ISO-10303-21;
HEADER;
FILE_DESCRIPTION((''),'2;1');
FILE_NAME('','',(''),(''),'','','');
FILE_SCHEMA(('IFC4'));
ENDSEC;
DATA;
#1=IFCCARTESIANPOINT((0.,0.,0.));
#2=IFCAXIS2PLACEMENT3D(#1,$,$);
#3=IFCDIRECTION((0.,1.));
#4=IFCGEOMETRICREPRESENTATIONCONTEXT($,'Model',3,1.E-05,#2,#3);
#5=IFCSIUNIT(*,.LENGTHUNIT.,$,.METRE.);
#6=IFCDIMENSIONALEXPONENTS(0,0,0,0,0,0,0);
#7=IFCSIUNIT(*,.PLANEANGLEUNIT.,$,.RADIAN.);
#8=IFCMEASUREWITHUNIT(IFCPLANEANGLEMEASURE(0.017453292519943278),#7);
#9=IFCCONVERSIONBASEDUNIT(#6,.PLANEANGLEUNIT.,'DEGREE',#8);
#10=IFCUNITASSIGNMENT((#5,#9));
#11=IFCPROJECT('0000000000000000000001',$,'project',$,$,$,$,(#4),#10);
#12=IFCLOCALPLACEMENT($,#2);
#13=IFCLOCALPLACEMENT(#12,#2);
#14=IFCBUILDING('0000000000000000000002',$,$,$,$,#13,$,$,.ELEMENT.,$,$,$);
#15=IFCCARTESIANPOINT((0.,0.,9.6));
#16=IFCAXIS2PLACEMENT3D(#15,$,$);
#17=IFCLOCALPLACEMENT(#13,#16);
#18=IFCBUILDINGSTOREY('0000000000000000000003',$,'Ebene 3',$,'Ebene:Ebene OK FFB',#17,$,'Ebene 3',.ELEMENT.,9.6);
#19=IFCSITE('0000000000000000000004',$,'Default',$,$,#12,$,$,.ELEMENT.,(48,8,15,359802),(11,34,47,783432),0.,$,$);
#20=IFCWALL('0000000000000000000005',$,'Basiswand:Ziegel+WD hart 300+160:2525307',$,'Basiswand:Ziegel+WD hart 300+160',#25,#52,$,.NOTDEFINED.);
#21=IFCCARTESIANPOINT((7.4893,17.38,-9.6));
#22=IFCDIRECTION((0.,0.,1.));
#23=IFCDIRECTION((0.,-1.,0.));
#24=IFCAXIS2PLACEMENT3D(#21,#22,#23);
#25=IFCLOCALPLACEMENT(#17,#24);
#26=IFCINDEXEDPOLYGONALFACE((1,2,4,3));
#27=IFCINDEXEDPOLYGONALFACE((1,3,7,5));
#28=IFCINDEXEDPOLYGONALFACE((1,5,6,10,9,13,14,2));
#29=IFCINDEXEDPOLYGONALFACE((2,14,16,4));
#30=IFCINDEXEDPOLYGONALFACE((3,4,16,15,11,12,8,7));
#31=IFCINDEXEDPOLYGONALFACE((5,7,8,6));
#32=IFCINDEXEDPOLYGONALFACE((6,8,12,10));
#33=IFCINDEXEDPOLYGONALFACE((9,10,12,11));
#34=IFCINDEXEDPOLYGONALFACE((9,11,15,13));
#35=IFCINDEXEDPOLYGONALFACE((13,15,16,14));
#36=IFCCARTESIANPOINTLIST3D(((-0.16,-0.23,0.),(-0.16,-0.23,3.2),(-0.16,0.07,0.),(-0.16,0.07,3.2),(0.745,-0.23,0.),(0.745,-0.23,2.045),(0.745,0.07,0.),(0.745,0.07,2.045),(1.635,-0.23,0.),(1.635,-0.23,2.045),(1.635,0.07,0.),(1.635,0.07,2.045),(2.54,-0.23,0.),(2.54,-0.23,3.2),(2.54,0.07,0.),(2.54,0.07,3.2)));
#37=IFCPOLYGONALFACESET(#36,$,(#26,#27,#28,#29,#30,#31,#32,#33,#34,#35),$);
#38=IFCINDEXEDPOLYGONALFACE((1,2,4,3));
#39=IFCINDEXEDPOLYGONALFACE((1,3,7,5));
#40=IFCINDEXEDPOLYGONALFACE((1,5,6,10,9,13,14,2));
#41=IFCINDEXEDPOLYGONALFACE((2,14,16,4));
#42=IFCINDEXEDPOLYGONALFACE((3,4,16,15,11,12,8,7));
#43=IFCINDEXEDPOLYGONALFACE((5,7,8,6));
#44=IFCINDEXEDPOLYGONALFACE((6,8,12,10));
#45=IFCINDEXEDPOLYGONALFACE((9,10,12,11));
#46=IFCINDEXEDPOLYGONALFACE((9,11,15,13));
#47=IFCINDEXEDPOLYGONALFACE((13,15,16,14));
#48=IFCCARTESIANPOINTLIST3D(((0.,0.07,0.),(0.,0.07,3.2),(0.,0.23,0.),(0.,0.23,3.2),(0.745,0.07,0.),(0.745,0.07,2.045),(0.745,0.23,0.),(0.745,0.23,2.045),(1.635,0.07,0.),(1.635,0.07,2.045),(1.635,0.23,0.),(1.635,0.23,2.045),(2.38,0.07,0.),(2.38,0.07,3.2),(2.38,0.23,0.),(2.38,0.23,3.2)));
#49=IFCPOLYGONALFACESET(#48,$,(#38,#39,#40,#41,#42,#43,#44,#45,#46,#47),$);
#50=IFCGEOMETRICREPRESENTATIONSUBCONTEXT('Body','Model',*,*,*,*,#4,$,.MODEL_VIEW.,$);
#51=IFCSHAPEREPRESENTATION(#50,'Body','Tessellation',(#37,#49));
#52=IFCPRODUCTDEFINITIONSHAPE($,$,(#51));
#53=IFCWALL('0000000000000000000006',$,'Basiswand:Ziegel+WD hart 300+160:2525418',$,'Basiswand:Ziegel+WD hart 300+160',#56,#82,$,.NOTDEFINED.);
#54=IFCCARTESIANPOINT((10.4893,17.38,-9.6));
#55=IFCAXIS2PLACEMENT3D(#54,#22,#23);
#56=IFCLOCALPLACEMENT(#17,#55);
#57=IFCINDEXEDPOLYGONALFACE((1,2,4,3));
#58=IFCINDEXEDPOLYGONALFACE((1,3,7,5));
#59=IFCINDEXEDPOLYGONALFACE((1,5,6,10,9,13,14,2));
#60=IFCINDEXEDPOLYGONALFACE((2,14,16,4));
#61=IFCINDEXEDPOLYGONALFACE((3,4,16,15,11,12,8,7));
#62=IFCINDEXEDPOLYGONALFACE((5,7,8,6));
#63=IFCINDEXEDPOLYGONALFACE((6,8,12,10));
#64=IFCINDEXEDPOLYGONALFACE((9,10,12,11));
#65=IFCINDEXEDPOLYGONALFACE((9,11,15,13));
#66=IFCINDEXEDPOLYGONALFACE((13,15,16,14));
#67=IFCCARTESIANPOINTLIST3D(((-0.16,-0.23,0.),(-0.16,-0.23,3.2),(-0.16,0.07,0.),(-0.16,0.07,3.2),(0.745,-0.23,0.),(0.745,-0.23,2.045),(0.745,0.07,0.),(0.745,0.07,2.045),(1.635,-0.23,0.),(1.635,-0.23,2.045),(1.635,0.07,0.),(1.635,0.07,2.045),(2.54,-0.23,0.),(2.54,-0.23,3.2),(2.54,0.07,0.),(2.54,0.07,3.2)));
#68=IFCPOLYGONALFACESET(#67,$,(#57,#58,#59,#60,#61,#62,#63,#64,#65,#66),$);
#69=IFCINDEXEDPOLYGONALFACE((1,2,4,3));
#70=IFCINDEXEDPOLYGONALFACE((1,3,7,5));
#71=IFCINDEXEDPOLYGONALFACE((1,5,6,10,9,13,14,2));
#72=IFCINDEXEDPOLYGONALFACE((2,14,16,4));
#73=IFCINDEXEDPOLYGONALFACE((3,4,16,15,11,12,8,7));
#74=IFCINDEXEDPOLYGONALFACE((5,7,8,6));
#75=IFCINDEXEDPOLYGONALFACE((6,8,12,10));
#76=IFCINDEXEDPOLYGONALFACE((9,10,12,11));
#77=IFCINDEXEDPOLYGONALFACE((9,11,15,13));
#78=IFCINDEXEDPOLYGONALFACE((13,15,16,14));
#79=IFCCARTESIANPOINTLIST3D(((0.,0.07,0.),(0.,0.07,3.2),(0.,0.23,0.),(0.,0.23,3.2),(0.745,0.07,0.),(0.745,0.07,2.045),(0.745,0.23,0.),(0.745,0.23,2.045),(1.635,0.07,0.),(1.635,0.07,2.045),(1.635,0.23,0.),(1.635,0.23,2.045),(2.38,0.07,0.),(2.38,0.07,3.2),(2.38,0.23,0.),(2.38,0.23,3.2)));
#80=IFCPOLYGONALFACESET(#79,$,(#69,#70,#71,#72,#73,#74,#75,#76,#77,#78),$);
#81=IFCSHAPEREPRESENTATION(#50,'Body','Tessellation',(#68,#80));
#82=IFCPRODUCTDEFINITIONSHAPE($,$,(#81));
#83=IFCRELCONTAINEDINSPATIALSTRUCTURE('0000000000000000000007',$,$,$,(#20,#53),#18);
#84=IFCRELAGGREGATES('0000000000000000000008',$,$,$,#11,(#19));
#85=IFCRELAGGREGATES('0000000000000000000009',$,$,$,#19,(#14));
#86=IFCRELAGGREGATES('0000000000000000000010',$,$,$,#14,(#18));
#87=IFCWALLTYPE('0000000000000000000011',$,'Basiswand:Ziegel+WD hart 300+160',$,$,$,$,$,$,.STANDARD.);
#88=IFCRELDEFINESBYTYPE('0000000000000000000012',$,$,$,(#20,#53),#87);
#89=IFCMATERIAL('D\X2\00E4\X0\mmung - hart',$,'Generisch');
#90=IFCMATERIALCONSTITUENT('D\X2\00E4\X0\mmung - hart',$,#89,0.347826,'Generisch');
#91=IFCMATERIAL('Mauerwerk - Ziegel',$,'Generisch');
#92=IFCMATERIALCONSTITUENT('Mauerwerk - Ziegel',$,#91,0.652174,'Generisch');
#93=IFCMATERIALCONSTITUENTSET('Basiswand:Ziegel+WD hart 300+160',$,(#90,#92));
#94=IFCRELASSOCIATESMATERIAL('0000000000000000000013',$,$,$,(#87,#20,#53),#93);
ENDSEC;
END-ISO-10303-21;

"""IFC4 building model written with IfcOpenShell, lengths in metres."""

from ifc_helpers import new_model, entity, si_unit, converted_unit, direction, frame, origin, place, context, subcontext, project, spatial, indexed_curve, outline, extrude, material, constituent, constituent_set, type_object, element, save


model = new_model("IFC4")

# Units and contexts
model_context = context("Model", 3, precision=1e-05, world=origin(), true_north=direction((0.0, 1.0)))
body_context = subcontext(model_context, "Body", "Model", "MODEL_VIEW")
ifc_project = project(units=[si_unit("LENGTHUNIT", "METRE"), converted_unit("PLANEANGLEUNIT", "DEGREE", entity("IfcPlaneAngleMeasure", 0.017453292519943278), si_unit("PLANEANGLEUNIT", "RADIAN"), dimensions=[0, 0, 0, 0, 0, 0, 0])], contexts=[model_context])

# Site, building, storey
site_placement = place(None, origin())
site = spatial("IfcSite", under=ifc_project, at=site_placement, Name="Default", CompositionType="ELEMENT", RefLatitude=(48, 8, 15, 359802), RefLongitude=(11, 34, 47, 783432), RefElevation=0.0)
building_placement = place(site_placement, origin())
building = spatial("IfcBuilding", under=site, at=building_placement, CompositionType="ELEMENT")
storey_placement = place(building_placement, frame((0.0, 0.0, 9.6)))
storey = spatial("IfcBuildingStorey", under=building, at=storey_placement, Name="Ebene 3", ObjectType="Ebene:Ebene OK FFB", LongName="Ebene 3", CompositionType="ELEMENT", Elevation=9.6)

# Shared definitions
ifc_material_1 = material(Name="Dämmung - hart", Category="Generisch")
ifc_constituent_1 = constituent(ifc_material_1, Name="Dämmung - hart", Category="Generisch", fraction=0.347826)
ifc_material_2 = material(Name="Mauerwerk - Ziegel", Category="Generisch")
ifc_constituent_2 = constituent(ifc_material_2, Name="Mauerwerk - Ziegel", Category="Generisch", fraction=0.652174)
ifc_constituent_set = constituent_set(constituents=[ifc_constituent_1, ifc_constituent_2], Name="Basiswand:Ziegel+WD hart 300+160")
wall_type = type_object("IfcWallType", Name="Basiswand:Ziegel+WD hart 300+160", PredefinedType="STANDARD", material=ifc_constituent_set)

# Walls, openings
wall_1_placement = place(storey_placement, frame((7.4893, 17.38, -9.6), z_axis=(0.0, 0.0, 1.0), x_axis=(0.0, -1.0, 0.0)))
wall_1 = element("IfcWall", 1, at=wall_1_placement, inside=storey, type_object=wall_type, material=ifc_constituent_set, Name="Basiswand:Ziegel+WD hart 300+160:2525307", ObjectType="Basiswand:Ziegel+WD hart 300+160", PredefinedType="NOTDEFINED", context=body_context, shape_type="SweptSolid", body=[
    extrude(outline(indexed_curve([(-1.8888, -1.35), (1.3112, -1.35), (1.3112, -0.445), (-0.7337, -0.445), (-0.7337, 0.445), (1.3112, 0.445), (1.3112, 1.35), (-1.8888, 1.35), (-1.8888, -1.35)], self_intersect=False)), frame((1.19, -0.23, 1.3112), z_axis=(0.0, 1.0, 0.0), x_axis=(0.0, 0.0, -1.0)), (0.0, 0.0, 1.0), 0.3),
    extrude(outline(indexed_curve([(-1.3112, -1.19), (1.8888, -1.19), (1.8888, 1.19), (-1.3112, 1.19), (-1.3112, 0.445), (0.7337, 0.445), (0.7337, -0.445), (-1.3112, -0.445), (-1.3112, -1.19)], self_intersect=False)), frame((1.19, 0.07, 1.3112), z_axis=(0.0, 1.0, 0.0), x_axis=(0.0, 0.0, 1.0)), (0.0, 0.0, 1.0), 0.16),
])
opening_1_placement = place(wall_1_placement, frame((0.745, -0.23, -0.18)))
element("IfcOpeningElement", 2, at=opening_1_placement, cuts=wall_1, PredefinedType="OPENING", context=body_context, shape_type="SweptSolid", body=[
    extrude(outline(indexed_curve([(2.225, 0.89), (0.0, 0.89), (0.0, 0.0), (2.225, 0.0), (2.225, 0.89)], self_intersect=False)), frame((0.0, 0.0, 0.0), z_axis=(0.0, 1.0, 0.0), x_axis=(0.0, 0.0, 1.0)), (0.0, 0.0, 1.0), 0.46),
])
wall_2_placement = place(storey_placement, frame((10.4893, 17.38, -9.6), z_axis=(0.0, 0.0, 1.0), x_axis=(0.0, -1.0, 0.0)))
wall_2 = element("IfcWall", 3, at=wall_2_placement, inside=storey, type_object=wall_type, material=ifc_constituent_set, Name="Basiswand:Ziegel+WD hart 300+160:2525418", ObjectType="Basiswand:Ziegel+WD hart 300+160", PredefinedType="NOTDEFINED", context=body_context, shape_type="SweptSolid", body=[
    extrude(outline(indexed_curve([(-1.8888, -1.35), (1.3112, -1.35), (1.3112, -0.445), (-0.7337, -0.445), (-0.7337, 0.445), (1.3112, 0.445), (1.3112, 1.35), (-1.8888, 1.35), (-1.8888, -1.35)], self_intersect=False)), frame((1.19, -0.23, 1.3112), z_axis=(0.0, 1.0, 0.0), x_axis=(0.0, 0.0, -1.0)), (0.0, 0.0, 1.0), 0.3),
    extrude(outline(indexed_curve([(-1.3112, -1.19), (1.8888, -1.19), (1.8888, 1.19), (-1.3112, 1.19), (-1.3112, 0.445), (0.7337, 0.445), (0.7337, -0.445), (-1.3112, -0.445), (-1.3112, -1.19)], self_intersect=False)), frame((1.19, 0.07, 1.3112), z_axis=(0.0, 1.0, 0.0), x_axis=(0.0, 0.0, 1.0)), (0.0, 0.0, 1.0), 0.16),
])
opening_2_placement = place(wall_2_placement, frame((0.745, -0.23, -0.18)))
element("IfcOpeningElement", 4, at=opening_2_placement, cuts=wall_2, PredefinedType="OPENING", context=body_context, shape_type="SweptSolid", body=[
    extrude(outline(indexed_curve([(2.225, 0.89), (0.0, 0.89), (0.0, 0.0), (2.225, 0.0), (2.225, 0.89)], self_intersect=False)), frame((0.0, 0.0, 0.0), z_axis=(0.0, 1.0, 0.0), x_axis=(0.0, 0.0, 1.0)), (0.0, 0.0, 1.0), 0.46),
])

save(model, "model.ifc")
